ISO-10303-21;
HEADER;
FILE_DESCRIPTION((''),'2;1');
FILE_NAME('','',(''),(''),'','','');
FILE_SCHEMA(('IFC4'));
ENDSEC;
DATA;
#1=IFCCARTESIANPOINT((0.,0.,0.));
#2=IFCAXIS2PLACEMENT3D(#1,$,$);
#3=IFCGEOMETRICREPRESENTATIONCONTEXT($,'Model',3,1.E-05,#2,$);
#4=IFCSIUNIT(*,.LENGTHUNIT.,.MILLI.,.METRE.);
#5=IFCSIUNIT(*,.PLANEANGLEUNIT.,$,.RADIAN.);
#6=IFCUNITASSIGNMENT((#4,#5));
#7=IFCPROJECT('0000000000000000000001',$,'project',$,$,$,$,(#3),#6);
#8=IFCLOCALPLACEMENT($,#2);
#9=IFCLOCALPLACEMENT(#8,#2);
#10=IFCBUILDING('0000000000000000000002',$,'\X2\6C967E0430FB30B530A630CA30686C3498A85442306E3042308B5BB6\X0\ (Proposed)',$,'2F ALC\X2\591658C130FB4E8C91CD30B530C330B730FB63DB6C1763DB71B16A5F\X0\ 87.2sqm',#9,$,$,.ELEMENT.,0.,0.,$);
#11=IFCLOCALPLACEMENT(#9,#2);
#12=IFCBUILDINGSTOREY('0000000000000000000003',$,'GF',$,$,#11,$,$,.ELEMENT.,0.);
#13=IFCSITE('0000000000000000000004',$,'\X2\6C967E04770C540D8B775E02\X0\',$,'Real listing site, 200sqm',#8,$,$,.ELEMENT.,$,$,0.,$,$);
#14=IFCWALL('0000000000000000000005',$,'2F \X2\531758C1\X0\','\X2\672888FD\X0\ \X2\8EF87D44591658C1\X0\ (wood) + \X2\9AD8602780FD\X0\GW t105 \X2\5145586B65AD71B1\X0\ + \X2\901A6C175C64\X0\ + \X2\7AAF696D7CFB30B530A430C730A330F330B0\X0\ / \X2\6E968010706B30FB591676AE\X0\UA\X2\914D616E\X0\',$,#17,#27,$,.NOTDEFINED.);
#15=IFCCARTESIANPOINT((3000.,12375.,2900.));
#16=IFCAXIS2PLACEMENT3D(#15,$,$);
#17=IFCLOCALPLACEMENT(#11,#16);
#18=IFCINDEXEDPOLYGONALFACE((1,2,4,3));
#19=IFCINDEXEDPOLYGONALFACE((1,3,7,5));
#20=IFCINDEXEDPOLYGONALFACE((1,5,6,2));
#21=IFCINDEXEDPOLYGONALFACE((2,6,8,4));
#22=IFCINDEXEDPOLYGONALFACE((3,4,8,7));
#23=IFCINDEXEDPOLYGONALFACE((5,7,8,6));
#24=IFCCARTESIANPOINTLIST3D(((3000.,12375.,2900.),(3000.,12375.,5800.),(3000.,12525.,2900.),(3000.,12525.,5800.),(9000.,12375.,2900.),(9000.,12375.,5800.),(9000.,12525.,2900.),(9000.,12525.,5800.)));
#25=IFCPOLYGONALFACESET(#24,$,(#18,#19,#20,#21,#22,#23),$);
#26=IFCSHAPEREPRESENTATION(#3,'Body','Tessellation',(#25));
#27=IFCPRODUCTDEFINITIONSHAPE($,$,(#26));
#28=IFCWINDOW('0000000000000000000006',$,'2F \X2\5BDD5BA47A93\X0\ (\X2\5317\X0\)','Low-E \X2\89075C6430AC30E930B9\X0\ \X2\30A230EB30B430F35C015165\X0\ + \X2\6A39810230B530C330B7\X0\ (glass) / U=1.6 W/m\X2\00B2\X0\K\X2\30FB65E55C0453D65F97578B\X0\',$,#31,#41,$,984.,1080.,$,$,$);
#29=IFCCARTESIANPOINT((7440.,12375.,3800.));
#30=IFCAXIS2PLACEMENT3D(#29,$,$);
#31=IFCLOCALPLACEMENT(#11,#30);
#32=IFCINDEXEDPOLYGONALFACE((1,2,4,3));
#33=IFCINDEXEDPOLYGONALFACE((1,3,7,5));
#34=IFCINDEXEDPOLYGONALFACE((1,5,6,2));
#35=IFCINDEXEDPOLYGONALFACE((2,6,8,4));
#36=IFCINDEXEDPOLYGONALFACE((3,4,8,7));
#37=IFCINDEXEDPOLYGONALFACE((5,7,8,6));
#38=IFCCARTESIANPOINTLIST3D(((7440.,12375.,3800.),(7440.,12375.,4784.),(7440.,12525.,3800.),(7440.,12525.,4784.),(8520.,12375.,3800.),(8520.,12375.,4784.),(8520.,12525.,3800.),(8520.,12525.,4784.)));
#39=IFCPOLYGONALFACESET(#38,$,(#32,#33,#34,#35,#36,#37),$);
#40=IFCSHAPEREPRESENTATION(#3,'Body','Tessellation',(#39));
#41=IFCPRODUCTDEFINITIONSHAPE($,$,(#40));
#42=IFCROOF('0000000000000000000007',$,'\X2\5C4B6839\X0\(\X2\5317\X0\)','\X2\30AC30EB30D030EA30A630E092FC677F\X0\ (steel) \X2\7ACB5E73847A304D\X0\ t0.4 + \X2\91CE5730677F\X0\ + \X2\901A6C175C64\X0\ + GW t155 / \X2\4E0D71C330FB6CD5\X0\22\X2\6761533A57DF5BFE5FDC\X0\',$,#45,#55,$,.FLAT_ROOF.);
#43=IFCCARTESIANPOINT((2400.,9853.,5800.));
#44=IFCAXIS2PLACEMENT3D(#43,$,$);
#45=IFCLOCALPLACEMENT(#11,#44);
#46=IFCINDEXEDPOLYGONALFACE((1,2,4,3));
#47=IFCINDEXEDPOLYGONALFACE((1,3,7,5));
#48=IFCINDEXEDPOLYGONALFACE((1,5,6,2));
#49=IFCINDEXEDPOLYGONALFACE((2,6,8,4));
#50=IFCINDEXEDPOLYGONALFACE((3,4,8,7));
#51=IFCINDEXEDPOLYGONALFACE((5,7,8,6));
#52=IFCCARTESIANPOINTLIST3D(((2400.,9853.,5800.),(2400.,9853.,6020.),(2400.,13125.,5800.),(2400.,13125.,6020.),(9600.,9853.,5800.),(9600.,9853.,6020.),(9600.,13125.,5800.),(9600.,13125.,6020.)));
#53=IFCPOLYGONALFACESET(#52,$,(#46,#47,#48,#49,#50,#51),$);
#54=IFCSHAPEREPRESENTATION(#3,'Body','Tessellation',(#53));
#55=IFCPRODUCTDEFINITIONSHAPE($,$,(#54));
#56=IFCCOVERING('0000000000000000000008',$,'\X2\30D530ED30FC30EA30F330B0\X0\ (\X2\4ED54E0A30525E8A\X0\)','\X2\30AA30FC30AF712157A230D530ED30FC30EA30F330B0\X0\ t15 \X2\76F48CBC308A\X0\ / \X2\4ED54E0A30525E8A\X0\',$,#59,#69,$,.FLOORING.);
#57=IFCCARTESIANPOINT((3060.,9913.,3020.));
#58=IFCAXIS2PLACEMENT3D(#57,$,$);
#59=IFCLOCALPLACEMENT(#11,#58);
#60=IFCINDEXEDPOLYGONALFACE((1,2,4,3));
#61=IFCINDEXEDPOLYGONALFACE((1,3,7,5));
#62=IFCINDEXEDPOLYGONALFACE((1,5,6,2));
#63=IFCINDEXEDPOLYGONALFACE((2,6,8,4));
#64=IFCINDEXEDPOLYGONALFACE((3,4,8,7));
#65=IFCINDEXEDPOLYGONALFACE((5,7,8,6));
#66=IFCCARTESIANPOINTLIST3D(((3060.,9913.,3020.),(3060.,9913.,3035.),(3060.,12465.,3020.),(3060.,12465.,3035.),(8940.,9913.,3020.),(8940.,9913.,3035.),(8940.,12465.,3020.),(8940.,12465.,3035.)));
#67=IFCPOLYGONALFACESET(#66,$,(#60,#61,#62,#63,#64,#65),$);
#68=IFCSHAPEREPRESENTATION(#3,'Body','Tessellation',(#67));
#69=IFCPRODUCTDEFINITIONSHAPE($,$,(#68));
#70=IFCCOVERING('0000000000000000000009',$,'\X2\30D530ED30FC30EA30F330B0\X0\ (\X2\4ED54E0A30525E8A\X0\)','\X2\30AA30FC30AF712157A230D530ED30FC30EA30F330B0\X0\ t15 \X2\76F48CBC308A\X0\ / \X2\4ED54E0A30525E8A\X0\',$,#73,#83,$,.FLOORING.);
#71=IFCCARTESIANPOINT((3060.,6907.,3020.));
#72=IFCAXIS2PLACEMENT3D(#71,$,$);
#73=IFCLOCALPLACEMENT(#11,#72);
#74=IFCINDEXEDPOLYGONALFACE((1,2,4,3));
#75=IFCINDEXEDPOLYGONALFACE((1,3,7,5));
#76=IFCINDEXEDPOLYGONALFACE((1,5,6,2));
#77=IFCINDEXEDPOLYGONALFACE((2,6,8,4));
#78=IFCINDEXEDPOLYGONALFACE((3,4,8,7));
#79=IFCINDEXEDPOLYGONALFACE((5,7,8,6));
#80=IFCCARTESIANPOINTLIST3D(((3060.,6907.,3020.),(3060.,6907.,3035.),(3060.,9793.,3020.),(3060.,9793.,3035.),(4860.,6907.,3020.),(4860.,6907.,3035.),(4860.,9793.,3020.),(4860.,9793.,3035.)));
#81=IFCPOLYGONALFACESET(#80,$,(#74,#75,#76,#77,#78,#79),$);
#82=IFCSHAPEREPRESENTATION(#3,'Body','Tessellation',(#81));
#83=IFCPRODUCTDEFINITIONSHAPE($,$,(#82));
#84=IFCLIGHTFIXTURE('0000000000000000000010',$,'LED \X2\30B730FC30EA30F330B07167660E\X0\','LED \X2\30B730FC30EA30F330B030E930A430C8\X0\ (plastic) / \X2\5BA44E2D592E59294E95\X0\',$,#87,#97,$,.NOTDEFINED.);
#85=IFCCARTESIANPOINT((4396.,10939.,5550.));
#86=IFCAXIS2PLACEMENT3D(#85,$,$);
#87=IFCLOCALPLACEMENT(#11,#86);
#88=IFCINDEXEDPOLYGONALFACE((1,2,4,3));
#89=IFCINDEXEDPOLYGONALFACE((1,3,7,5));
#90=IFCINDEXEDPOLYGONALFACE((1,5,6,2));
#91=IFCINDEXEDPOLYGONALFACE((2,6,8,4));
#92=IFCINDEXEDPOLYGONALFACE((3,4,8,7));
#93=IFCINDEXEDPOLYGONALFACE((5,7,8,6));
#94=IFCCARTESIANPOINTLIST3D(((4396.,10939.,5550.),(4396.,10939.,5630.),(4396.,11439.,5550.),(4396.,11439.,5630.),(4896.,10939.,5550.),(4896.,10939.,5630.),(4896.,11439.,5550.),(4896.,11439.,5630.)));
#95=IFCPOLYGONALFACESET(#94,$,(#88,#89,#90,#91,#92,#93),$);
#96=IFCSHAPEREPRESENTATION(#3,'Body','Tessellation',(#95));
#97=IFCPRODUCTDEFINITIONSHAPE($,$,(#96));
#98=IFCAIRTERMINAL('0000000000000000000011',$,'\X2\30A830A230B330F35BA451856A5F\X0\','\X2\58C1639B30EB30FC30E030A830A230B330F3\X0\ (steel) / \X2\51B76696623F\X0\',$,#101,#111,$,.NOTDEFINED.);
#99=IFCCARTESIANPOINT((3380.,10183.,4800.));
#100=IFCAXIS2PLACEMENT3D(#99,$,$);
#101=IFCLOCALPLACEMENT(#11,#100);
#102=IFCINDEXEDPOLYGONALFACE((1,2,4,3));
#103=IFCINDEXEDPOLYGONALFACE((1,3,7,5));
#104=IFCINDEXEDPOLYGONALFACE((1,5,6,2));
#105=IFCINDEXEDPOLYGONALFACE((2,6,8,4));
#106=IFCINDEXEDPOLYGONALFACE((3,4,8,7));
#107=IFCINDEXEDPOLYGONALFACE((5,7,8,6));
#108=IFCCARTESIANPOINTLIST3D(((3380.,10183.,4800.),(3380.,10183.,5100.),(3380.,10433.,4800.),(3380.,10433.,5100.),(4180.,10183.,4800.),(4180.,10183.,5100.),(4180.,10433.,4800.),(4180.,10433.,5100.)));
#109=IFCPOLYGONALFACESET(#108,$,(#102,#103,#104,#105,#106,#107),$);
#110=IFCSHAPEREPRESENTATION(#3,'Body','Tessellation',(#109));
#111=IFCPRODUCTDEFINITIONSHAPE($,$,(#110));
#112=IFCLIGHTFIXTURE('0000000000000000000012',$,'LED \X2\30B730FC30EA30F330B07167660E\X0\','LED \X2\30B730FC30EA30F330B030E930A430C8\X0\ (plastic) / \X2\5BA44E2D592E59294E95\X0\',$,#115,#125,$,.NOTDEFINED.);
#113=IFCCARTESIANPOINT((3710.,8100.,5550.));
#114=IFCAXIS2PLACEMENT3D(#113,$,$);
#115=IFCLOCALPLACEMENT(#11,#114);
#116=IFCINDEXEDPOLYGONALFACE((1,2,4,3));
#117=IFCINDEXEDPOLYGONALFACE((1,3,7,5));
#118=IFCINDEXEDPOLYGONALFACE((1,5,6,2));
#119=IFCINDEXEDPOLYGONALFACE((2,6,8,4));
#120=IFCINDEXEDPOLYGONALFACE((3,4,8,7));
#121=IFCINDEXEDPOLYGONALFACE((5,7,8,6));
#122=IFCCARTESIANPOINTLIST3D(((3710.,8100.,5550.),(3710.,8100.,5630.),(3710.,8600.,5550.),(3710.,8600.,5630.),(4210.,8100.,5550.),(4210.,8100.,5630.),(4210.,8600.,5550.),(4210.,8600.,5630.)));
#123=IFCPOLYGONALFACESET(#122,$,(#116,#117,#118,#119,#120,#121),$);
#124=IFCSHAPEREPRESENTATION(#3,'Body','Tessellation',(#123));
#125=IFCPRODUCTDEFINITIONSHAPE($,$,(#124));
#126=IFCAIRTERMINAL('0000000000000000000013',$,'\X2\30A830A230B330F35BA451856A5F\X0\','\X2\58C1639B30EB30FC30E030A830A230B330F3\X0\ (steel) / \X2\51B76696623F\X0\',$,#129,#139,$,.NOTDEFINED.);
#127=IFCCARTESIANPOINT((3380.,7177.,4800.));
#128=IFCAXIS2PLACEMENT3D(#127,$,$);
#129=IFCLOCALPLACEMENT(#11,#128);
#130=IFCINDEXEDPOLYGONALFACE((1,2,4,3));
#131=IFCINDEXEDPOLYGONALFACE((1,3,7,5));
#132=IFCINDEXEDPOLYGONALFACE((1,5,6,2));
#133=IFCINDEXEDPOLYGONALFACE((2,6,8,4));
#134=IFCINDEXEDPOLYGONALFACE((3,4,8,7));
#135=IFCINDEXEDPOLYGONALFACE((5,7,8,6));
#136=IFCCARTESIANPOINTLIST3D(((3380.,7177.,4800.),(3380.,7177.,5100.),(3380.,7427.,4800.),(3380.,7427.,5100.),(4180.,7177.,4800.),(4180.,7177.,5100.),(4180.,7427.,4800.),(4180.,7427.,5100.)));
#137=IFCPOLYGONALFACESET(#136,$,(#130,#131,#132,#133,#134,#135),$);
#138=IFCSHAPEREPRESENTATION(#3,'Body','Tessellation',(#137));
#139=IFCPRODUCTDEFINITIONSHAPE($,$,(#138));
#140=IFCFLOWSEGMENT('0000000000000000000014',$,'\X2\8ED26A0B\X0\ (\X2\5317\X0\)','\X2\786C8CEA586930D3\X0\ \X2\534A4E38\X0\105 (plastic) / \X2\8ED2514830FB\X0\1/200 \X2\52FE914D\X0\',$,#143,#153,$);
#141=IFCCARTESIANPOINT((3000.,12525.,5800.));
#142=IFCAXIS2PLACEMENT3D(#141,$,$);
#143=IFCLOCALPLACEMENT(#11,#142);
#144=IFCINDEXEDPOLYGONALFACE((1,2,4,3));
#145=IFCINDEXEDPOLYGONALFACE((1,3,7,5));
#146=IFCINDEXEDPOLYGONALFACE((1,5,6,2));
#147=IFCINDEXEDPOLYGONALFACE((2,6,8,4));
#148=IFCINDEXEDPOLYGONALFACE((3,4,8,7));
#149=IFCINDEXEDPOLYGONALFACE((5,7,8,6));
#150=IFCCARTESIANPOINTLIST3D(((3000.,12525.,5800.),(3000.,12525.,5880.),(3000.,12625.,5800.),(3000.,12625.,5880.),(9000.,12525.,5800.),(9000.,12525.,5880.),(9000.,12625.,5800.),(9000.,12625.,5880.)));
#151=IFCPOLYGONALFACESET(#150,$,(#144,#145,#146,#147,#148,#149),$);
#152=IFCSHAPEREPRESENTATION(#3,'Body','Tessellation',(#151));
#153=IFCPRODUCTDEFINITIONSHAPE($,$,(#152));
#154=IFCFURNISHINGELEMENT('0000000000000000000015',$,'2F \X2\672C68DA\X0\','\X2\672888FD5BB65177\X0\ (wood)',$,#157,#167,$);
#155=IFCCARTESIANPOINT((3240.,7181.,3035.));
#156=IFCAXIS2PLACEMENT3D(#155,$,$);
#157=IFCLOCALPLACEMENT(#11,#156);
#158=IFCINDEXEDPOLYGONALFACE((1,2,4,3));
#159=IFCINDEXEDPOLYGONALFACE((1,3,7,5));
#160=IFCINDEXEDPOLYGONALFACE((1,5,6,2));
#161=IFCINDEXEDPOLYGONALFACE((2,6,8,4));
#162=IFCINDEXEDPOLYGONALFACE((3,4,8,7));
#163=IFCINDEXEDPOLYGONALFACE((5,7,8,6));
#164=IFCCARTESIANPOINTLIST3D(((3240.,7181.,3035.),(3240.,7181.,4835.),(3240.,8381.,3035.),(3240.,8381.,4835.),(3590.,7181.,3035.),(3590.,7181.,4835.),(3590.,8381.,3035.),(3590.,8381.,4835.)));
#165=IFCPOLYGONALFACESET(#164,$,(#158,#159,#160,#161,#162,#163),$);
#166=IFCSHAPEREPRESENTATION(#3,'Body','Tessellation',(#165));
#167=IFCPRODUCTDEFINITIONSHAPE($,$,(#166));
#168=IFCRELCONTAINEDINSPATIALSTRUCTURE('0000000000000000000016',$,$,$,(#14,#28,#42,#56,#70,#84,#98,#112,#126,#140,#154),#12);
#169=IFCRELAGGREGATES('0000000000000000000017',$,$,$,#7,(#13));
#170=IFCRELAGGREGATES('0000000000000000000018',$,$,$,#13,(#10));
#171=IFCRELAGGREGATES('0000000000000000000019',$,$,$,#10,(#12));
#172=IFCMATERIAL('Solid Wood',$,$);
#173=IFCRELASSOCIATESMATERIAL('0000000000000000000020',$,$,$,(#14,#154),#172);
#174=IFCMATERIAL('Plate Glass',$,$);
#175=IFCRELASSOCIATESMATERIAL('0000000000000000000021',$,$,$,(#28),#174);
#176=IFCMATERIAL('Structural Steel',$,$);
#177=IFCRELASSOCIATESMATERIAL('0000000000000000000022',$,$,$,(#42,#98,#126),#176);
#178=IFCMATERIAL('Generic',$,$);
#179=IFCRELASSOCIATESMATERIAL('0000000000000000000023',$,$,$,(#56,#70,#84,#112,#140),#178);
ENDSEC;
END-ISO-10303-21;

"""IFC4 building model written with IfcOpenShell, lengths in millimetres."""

from ifc_helpers import new_model, si_unit, frame, frame_2d, origin, place, context, project, spatial, rectangle, extrude, material, element, fill, save


model = new_model("IFC4")

# Units and contexts
model_context = context("Model", 3, precision=1e-05, world=origin())
ifc_project = project(units=[si_unit("LENGTHUNIT", "METRE", prefix="MILLI"), si_unit("PLANEANGLEUNIT", "RADIAN")], contexts=[model_context])

# Site, building, storey
site_placement = place(None, origin())
site = spatial("IfcSite", under=ifc_project, at=site_placement, Name="沖縄県名護市", ObjectType="Real listing site, 200sqm", CompositionType="ELEMENT", RefElevation=0.0)
building_placement = place(site_placement, origin())
building = spatial("IfcBuilding", under=site, at=building_placement, Name="沖縄・サウナと水風呂のある家 (Proposed)", ObjectType="2F ALC外壁・二重サッシ・換気換熱機 87.2sqm", CompositionType="ELEMENT", ElevationOfRefHeight=0.0, ElevationOfTerrain=0.0)
storey_placement = place(building_placement, origin())
storey = spatial("IfcBuildingStorey", under=building, at=storey_placement, Name="GF", CompositionType="ELEMENT", Elevation=0.0)

# Shared definitions
ifc_material_1 = material(Name="Solid Wood")

# Wall, opening, window
wall_placement = place(storey_placement, frame((3000.0, 12375.0, 2900.0)))
wall = element("IfcWall", 1, at=wall_placement, inside=storey, material=ifc_material_1, Name="2F 北壁", Description="木製 軸組外壁 (wood) + 高性能GW t105 充填断熱 + 通気層 + 窯業系サイディング / 準耐火・外皮UA配慮", PredefinedType="NOTDEFINED", context=model_context, shape_type="SweptSolid", body=[
    extrude(rectangle(XDim=6000.0, YDim=150.0, at=frame_2d((3000.0, 75.0))), frame((3000.0, 12375.0, 2900.0)), (0.0, 0.0, 1.0), 2900.0),
])
opening_placement = place(storey_placement, frame((7440.0, 12375.0, 3800.0)))
opening = element("IfcOpeningElement", 2, at=opening_placement, cuts=wall, PredefinedType="NOTDEFINED", context=model_context, shape_type="SweptSolid", body=[
    extrude(rectangle(XDim=1080.0, YDim=150.0, at=frame_2d((540.0, 75.0))), frame((7440.0, 12375.0, 3800.0)), (0.0, 0.0, 1.0), 984.0),
])
ifc_material_2 = material(Name="Plate Glass")
window_placement = place(storey_placement, frame((7440.0, 12375.0, 3800.0)))
window = element("IfcWindow", 3, at=window_placement, inside=storey, material=ifc_material_2, Name="2F 寝室窓 (北)", Description="Low-E 複層ガラス アルゴン封入 + 樹脂サッシ (glass) / U=1.6 W/m²K・日射取得型", OverallHeight=984.0, OverallWidth=1080.0, context=model_context, shape_type="SweptSolid", body=[
    extrude(rectangle(XDim=1080.0, YDim=150.0, at=frame_2d((540.0, 75.0))), frame((7440.0, 12375.0, 3800.0)), (0.0, 0.0, 1.0), 984.0),
])
fill(opening, window)

# Roof
ifc_material_3 = material(Name="Structural Steel")
for number, where, name in (
    (4, (2400.0, 9853.0, 5800.0), "屋根(北)"),
):
    element("IfcRoof", number, at=place(storey_placement, frame(where)), inside=storey, material=ifc_material_3, Name=name, Description="ガルバリウム鋼板 (steel) 立平葺き t0.4 + 野地板 + 通気層 + GW t155 / 不燃・法22条区域対応", PredefinedType="FLAT_ROOF", context=model_context, shape_type="SweptSolid", body=[
        extrude(rectangle(XDim=7200.0, YDim=3272.0, at=frame_2d((3600.0, 1636.0))), frame((2400.0, 9853.0, 5800.0)), (0.0, 0.0, 1.0), 220.0),
    ])

# Coverings
ifc_material_4 = material(Name="Generic")
covering_1_placement = place(storey_placement, frame((3060.0, 9913.0, 3020.0)))
element("IfcCovering", 5, at=covering_1_placement, inside=storey, material=ifc_material_4, Name="フローリング (仕上げ床)", Description="オーク無垢フローリング t15 直貼り / 仕上げ床", PredefinedType="FLOORING", context=model_context, shape_type="SweptSolid", body=[
    extrude(rectangle(XDim=5880.0, YDim=2552.0, at=frame_2d((2940.0, 1276.0))), frame((3060.0, 9913.0, 3020.0)), (0.0, 0.0, 1.0), 15.0),
])
covering_2_placement = place(storey_placement, frame((3060.0, 6907.0, 3020.0)))
element("IfcCovering", 6, at=covering_2_placement, inside=storey, material=ifc_material_4, Name="フローリング (仕上げ床)", Description="オーク無垢フローリング t15 直貼り / 仕上げ床", PredefinedType="FLOORING", context=model_context, shape_type="SweptSolid", body=[
    extrude(rectangle(XDim=1800.0, YDim=2886.0, at=frame_2d((900.0, 1443.0))), frame((3060.0, 6907.0, 3020.0)), (0.0, 0.0, 1.0), 15.0),
])

# Light fixture
light_fixture_1_placement = place(storey_placement, frame((4396.0, 10939.0, 5550.0)))
element("IfcLightFixture", 7, at=light_fixture_1_placement, inside=storey, material=ifc_material_4, Name="LED シーリング照明", Description="LED シーリングライト (plastic) / 室中央天井", PredefinedType="NOTDEFINED", context=model_context, shape_type="SweptSolid", body=[
    extrude(rectangle(XDim=500.0, YDim=500.0, at=frame_2d((250.0, 250.0))), frame((4396.0, 10939.0, 5550.0)), (0.0, 0.0, 1.0), 80.0),
])

# Air terminal
air_terminal_1_placement = place(storey_placement, frame((3380.0, 10183.0, 4800.0)))
element("IfcAirTerminal", 8, at=air_terminal_1_placement, inside=storey, material=ifc_material_3, Name="エアコン室内機", Description="壁掛ルームエアコン (steel) / 冷暖房", PredefinedType="NOTDEFINED", context=model_context, shape_type="SweptSolid", body=[
    extrude(rectangle(XDim=800.0, YDim=250.0, at=frame_2d((400.0, 125.0))), frame((3380.0, 10183.0, 4800.0)), (0.0, 0.0, 1.0), 300.0),
])

# Light fixture
light_fixture_2_placement = place(storey_placement, frame((3710.0, 8100.0, 5550.0)))
element("IfcLightFixture", 9, at=light_fixture_2_placement, inside=storey, material=ifc_material_4, Name="LED シーリング照明", Description="LED シーリングライト (plastic) / 室中央天井", PredefinedType="NOTDEFINED", context=model_context, shape_type="SweptSolid", body=[
    extrude(rectangle(XDim=500.0, YDim=500.0, at=frame_2d((250.0, 250.0))), frame((3710.0, 8100.0, 5550.0)), (0.0, 0.0, 1.0), 80.0),
])

# Air terminal
air_terminal_2_placement = place(storey_placement, frame((3380.0, 7177.0, 4800.0)))
element("IfcAirTerminal", 10, at=air_terminal_2_placement, inside=storey, material=ifc_material_3, Name="エアコン室内機", Description="壁掛ルームエアコン (steel) / 冷暖房", PredefinedType="NOTDEFINED", context=model_context, shape_type="SweptSolid", body=[
    extrude(rectangle(XDim=800.0, YDim=250.0, at=frame_2d((400.0, 125.0))), frame((3380.0, 7177.0, 4800.0)), (0.0, 0.0, 1.0), 300.0),
])

# Flow segment
flow_segment_placement = place(storey_placement, frame((3000.0, 12525.0, 5800.0)))
element("IfcFlowSegment", 11, at=flow_segment_placement, inside=storey, material=ifc_material_4, Name="軒樋 (北)", Description="硬質塩ビ 半丸105 (plastic) / 軒先・1/200 勾配", context=model_context, shape_type="SweptSolid", body=[
    extrude(rectangle(XDim=6000.0, YDim=100.0, at=frame_2d((3000.0, 50.0))), frame((3000.0, 12525.0, 5800.0)), (0.0, 0.0, 1.0), 80.0),
])

# Furnishing element
furnishing_placement = place(storey_placement, frame((3240.0, 7181.0, 3035.0)))
element("IfcFurnishingElement", 12, at=furnishing_placement, inside=storey, material=ifc_material_1, Name="2F 本棚", Description="木製家具 (wood)", context=model_context, shape_type="SweptSolid", body=[
    extrude(rectangle(XDim=350.0, YDim=1200.0, at=frame_2d((175.0, 600.0))), frame((3240.0, 7181.0, 3035.0)), (0.0, 0.0, 1.0), 1800.0),
])

save(model, "model.ifc")
